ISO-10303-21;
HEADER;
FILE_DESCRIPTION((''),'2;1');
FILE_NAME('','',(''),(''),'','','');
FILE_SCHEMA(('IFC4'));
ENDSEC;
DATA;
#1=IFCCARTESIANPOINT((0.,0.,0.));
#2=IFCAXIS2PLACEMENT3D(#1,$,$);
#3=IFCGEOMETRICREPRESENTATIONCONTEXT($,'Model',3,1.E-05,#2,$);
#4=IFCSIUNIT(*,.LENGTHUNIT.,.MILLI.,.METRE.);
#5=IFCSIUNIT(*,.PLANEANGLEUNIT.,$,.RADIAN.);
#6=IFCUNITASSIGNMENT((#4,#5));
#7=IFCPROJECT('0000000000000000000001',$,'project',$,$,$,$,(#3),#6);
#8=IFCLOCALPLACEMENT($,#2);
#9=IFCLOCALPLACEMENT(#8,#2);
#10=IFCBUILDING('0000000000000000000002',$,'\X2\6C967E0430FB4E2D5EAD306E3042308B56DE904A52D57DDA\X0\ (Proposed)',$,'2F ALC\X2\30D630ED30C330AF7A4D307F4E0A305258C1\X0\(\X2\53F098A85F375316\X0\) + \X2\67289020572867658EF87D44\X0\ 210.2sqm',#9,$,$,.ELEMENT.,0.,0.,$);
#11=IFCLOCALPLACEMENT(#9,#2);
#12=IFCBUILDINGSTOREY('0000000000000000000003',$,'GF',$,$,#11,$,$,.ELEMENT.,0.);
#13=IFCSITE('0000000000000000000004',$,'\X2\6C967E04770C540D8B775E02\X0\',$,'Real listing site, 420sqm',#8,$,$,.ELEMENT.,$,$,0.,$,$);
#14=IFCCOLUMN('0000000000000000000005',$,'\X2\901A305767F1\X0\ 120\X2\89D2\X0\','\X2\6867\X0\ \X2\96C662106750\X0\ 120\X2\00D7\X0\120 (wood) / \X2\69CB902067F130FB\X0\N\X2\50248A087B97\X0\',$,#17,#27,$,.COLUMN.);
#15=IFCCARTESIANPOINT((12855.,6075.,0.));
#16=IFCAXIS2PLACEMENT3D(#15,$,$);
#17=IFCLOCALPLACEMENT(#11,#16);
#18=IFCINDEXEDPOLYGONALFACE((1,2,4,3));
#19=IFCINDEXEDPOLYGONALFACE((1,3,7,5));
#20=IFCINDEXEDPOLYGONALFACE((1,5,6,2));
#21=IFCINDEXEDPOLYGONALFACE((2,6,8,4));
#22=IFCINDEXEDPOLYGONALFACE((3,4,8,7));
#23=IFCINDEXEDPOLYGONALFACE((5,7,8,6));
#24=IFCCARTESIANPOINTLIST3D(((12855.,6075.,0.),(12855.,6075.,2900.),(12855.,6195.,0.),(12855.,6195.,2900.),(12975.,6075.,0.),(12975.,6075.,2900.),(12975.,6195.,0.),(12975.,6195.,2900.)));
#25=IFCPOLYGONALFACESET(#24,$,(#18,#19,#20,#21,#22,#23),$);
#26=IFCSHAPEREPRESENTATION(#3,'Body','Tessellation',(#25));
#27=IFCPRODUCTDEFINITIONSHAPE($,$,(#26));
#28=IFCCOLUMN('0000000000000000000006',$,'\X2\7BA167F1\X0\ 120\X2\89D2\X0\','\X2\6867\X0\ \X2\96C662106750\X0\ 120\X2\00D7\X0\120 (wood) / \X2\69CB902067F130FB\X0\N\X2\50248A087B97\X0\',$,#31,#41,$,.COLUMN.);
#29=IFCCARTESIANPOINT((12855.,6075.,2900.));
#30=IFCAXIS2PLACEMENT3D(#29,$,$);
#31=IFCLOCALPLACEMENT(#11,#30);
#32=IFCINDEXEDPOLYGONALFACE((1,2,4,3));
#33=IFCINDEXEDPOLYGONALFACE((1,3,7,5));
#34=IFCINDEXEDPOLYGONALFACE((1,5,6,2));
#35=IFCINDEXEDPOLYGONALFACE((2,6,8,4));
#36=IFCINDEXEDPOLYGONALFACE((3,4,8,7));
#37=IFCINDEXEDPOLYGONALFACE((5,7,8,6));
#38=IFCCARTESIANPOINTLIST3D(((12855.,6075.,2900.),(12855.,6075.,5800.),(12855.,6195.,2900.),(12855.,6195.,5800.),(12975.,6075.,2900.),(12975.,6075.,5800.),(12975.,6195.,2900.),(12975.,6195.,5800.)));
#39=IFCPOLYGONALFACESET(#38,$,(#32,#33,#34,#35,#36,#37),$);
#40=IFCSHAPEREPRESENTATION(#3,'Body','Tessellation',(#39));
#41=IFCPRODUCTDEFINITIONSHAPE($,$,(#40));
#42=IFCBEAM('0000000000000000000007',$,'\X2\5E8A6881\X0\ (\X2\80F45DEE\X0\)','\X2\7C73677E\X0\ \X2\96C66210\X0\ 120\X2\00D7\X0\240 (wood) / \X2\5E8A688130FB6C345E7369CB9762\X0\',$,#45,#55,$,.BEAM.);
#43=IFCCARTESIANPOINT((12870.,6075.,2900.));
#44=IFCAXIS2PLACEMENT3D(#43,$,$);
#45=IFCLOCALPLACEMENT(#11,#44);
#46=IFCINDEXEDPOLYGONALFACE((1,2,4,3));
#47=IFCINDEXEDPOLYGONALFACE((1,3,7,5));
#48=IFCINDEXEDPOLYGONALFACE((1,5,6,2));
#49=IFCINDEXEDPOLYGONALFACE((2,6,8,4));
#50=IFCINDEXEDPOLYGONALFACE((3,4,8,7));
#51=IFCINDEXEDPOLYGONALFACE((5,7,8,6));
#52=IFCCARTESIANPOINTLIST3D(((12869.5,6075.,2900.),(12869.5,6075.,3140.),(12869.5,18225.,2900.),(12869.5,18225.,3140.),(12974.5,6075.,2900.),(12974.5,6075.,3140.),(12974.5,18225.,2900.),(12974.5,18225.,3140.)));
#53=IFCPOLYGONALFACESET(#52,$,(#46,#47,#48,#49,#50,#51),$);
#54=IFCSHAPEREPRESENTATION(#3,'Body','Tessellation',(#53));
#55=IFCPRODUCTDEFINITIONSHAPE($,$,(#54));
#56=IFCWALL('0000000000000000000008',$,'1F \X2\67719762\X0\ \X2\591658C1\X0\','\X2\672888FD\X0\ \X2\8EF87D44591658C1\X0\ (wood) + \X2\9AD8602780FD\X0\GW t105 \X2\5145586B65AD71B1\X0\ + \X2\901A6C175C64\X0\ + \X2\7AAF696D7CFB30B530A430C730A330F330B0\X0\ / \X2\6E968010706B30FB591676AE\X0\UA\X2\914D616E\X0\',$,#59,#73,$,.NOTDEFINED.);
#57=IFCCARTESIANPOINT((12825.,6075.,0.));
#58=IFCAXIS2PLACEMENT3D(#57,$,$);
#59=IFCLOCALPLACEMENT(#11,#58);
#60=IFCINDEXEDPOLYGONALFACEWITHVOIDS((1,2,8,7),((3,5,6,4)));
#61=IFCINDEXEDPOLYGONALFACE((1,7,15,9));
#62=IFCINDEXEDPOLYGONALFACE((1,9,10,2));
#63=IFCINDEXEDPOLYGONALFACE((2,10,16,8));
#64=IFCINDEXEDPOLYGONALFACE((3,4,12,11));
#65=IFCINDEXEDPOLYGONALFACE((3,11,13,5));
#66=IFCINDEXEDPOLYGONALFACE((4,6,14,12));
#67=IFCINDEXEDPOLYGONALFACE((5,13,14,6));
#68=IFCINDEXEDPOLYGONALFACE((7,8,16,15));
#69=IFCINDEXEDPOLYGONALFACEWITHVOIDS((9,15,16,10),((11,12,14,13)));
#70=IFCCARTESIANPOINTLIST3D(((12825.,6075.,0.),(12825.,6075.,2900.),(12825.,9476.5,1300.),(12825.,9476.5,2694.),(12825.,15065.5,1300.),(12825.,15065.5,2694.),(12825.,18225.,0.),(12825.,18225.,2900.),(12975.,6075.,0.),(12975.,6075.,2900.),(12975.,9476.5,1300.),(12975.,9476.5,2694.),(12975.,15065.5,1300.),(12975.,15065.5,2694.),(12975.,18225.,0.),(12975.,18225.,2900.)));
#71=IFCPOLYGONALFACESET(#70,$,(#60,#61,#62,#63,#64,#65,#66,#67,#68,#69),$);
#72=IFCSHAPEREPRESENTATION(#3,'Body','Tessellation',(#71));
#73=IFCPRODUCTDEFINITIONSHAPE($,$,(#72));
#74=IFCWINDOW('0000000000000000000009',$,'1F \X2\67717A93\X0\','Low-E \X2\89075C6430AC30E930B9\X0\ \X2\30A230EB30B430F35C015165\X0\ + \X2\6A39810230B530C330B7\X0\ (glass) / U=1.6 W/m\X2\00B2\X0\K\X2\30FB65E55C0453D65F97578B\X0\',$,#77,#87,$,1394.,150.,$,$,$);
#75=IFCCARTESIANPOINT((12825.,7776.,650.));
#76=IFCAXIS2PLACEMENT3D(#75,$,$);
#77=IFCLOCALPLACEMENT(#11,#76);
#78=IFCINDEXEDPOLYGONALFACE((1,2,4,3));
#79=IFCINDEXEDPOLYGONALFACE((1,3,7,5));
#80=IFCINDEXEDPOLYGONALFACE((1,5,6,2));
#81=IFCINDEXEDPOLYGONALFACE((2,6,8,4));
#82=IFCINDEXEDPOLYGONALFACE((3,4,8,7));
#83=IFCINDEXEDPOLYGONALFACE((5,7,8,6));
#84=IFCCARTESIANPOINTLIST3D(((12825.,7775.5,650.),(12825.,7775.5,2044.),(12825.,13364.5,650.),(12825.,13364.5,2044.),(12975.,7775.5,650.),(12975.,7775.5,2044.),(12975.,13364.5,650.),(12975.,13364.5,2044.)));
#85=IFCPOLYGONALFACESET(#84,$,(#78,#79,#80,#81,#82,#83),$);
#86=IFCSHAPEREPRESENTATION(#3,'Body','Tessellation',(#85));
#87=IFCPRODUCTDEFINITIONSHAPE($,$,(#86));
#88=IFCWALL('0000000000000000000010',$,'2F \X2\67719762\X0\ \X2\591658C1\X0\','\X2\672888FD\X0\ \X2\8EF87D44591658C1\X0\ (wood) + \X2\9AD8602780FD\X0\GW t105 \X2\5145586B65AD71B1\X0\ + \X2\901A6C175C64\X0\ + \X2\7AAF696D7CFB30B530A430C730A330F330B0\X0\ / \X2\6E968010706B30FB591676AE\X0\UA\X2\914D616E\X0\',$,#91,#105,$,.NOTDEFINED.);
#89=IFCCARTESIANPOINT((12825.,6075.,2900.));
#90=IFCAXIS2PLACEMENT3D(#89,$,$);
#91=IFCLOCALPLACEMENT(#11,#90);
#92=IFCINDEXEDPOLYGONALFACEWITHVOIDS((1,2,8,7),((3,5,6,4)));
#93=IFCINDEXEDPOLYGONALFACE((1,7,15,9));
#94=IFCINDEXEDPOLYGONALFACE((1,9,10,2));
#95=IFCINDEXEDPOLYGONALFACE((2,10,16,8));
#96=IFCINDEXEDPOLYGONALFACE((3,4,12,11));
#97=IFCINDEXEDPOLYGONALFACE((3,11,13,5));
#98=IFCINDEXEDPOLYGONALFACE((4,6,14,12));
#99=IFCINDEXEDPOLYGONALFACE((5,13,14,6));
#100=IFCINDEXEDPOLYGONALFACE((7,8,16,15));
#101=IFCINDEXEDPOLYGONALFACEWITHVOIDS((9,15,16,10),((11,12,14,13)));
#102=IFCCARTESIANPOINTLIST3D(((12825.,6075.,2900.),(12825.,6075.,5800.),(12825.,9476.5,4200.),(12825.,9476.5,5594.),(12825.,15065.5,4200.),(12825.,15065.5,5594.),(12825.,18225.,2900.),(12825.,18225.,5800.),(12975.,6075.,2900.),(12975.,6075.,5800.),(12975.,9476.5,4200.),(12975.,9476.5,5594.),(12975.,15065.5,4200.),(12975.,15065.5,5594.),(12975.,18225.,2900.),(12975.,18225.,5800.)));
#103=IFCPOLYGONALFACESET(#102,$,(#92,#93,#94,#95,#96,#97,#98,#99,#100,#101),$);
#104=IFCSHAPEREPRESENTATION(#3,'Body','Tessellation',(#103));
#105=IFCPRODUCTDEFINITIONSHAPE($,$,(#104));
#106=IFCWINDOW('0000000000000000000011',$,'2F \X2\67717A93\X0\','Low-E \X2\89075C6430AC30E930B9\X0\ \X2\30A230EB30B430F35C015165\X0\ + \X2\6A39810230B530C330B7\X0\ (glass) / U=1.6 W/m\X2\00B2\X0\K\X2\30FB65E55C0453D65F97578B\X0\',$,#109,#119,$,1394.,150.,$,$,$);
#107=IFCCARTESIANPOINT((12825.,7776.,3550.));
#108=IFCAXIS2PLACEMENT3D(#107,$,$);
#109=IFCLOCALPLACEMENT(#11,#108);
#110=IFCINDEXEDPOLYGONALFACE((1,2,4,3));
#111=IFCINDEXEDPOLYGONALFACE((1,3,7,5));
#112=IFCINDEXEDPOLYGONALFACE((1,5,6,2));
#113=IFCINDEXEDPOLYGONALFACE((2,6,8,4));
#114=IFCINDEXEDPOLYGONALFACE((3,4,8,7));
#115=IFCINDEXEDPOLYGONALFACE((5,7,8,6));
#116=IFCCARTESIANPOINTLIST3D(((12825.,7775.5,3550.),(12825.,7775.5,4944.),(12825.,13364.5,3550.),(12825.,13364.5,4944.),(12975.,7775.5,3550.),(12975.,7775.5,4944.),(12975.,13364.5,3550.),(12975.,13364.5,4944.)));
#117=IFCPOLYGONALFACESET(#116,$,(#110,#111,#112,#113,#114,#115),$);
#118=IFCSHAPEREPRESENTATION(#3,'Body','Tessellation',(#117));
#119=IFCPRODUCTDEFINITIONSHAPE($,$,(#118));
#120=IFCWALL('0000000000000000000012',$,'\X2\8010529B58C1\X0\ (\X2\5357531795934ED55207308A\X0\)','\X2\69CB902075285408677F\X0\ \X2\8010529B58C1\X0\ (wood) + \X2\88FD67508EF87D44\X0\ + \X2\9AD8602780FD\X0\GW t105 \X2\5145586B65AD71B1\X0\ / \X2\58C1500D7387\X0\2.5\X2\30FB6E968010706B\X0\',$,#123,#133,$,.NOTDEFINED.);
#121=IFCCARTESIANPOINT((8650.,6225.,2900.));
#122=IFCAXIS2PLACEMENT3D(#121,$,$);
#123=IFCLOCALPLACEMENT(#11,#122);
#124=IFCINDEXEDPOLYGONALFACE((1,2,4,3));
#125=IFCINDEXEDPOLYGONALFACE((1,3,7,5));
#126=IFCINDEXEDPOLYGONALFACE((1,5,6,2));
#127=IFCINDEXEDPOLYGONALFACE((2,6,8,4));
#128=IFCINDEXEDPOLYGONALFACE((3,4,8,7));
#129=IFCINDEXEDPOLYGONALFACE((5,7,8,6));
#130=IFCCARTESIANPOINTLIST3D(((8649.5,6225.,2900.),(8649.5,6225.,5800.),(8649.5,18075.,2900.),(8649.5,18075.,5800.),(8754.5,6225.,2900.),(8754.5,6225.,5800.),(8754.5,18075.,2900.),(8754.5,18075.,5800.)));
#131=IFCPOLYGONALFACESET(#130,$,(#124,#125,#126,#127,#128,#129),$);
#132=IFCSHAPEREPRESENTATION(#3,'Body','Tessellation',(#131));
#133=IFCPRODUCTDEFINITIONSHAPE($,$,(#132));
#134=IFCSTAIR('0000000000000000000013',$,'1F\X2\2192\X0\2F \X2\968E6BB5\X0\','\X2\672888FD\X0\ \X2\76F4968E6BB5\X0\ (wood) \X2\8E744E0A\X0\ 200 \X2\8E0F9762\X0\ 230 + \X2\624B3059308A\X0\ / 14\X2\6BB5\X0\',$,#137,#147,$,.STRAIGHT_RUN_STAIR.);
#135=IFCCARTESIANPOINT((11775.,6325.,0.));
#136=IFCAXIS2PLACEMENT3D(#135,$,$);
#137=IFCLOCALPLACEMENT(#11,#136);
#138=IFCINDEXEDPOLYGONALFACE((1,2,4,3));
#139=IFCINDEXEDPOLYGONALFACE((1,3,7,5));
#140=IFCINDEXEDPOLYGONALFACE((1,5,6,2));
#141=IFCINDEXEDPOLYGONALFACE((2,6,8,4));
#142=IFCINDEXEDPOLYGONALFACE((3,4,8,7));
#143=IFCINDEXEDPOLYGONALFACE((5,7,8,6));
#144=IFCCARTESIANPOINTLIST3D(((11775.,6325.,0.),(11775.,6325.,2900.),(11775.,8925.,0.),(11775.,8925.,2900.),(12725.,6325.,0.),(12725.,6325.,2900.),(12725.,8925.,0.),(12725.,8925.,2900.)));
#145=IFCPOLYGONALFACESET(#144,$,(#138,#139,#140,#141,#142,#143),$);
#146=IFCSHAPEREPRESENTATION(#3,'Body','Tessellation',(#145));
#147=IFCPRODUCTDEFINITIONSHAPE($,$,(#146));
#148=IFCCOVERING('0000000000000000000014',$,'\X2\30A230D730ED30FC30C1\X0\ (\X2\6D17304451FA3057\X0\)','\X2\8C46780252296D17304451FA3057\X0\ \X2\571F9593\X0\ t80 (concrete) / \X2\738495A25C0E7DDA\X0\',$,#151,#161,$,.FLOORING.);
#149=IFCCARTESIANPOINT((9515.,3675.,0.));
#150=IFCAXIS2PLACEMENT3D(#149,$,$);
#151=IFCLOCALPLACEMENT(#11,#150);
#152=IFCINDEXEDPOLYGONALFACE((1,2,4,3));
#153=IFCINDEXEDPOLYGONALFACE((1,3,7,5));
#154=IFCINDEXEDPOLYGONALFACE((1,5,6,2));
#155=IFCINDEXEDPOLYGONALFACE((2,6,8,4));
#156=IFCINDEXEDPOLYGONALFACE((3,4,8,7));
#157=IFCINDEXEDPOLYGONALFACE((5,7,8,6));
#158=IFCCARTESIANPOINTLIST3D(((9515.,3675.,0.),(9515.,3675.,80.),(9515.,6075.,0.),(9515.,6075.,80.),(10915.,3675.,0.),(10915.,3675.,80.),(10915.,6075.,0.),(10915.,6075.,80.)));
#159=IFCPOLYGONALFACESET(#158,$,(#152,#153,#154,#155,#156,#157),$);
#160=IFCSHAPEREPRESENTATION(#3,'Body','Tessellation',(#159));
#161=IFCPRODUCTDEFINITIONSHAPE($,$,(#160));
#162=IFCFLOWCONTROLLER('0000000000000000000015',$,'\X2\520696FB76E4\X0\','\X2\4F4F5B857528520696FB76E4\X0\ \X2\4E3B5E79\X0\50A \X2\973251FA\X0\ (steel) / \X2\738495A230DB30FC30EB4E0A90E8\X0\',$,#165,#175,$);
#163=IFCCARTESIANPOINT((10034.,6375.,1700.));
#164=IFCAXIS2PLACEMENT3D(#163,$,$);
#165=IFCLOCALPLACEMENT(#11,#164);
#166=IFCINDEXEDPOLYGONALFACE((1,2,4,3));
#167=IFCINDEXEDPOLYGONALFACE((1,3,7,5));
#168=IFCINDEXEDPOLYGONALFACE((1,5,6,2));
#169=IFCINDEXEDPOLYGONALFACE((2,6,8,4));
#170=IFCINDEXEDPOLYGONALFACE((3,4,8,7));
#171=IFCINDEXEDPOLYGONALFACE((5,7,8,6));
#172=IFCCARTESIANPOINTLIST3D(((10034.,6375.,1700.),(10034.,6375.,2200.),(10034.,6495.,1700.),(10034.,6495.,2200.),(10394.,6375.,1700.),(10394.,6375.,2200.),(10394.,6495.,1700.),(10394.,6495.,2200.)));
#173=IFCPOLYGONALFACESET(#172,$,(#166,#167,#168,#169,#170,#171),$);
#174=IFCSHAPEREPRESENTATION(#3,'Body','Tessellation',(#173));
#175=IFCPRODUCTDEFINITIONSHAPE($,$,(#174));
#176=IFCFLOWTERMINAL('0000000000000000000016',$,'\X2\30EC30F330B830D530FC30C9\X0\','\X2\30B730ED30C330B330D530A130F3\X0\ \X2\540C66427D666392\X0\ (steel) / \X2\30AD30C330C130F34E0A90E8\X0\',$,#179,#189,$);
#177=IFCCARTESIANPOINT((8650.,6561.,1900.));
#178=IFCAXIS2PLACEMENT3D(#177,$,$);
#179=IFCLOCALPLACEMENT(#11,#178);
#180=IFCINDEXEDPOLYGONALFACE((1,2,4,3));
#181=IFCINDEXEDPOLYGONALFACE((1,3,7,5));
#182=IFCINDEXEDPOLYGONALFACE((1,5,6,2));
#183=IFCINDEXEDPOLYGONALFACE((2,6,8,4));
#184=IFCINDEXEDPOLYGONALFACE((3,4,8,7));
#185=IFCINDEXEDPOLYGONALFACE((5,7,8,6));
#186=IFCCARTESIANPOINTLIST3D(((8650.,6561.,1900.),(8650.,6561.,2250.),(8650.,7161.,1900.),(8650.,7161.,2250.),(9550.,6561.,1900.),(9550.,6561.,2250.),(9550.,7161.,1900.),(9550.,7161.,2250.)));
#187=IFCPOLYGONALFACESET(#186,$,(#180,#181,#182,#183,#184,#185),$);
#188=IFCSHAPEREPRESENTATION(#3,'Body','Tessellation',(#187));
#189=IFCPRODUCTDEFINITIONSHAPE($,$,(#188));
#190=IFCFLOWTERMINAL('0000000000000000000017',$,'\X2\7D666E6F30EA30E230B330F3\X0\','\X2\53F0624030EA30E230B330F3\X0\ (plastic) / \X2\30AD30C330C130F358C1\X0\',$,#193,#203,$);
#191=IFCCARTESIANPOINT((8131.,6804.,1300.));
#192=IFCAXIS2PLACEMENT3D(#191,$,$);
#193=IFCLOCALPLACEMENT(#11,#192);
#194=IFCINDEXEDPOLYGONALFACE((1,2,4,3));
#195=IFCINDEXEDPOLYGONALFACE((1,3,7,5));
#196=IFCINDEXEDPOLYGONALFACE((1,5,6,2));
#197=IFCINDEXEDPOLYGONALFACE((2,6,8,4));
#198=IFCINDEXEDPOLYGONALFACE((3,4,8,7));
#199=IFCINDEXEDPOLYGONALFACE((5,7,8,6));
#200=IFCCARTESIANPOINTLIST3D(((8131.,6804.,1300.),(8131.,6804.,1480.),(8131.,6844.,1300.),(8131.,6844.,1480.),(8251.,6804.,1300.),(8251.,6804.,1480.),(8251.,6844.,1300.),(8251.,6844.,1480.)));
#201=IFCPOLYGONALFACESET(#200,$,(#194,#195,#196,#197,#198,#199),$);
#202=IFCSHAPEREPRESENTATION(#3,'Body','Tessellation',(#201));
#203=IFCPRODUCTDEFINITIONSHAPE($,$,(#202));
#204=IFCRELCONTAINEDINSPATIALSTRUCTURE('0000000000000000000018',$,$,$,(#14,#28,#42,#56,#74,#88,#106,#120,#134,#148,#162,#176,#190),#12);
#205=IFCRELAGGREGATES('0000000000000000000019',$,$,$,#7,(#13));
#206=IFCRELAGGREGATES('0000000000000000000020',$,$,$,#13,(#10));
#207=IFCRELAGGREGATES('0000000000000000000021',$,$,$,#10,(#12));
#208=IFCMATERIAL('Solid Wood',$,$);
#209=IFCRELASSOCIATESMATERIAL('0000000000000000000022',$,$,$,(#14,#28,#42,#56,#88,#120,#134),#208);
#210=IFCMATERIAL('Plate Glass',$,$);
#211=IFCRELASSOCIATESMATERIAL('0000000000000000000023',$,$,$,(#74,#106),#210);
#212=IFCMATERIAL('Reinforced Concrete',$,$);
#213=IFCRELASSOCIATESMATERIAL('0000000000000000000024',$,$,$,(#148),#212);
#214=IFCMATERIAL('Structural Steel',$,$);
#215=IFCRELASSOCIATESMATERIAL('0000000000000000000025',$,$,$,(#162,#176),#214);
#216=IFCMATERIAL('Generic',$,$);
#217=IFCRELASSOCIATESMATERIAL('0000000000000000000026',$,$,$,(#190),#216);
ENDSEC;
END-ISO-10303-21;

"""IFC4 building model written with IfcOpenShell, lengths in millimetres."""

from ifc_helpers import new_model, si_unit, frame, frame_2d, origin, place, context, project, spatial, rectangle, extrude, material, element, fill, save


model = new_model("IFC4")

# Units and contexts
model_context = context("Model", 3, precision=1e-05, world=origin())
ifc_project = project(units=[si_unit("LENGTHUNIT", "METRE", prefix="MILLI"), si_unit("PLANEANGLEUNIT", "RADIAN")], contexts=[model_context])

# Site, building, storey
site_placement = place(None, origin())
site = spatial("IfcSite", under=ifc_project, at=site_placement, Name="沖縄県名護市", ObjectType="Real listing site, 420sqm", CompositionType="ELEMENT", RefElevation=0.0)
building_placement = place(site_placement, origin())
building = spatial("IfcBuilding", under=site, at=building_placement, Name="沖縄・中庭のある回遊動線 (Proposed)", ObjectType="2F ALCブロック積み上げ壁(台風強化) + 木造在来軸組 210.2sqm", CompositionType="ELEMENT", ElevationOfRefHeight=0.0, ElevationOfTerrain=0.0)
storey_placement = place(building_placement, origin())
storey = spatial("IfcBuildingStorey", under=building, at=storey_placement, Name="GF", CompositionType="ELEMENT", Elevation=0.0)

# Columns
ifc_material_1 = material(Name="Solid Wood")
column_1_placement = place(storey_placement, frame((12855.0, 6075.0, 0.0)))
element("IfcColumn", 1, at=column_1_placement, inside=storey, material=ifc_material_1, Name="通し柱 120角", Description="桧 集成材 120×120 (wood) / 構造柱・N値計算", PredefinedType="COLUMN", context=model_context, shape_type="SweptSolid", body=[
    extrude(rectangle(XDim=120.0, YDim=120.0, at=frame_2d((60.0, 60.0))), frame((12855.0, 6075.0, 0.0)), (0.0, 0.0, 1.0), 2900.0),
])
column_2_placement = place(storey_placement, frame((12855.0, 6075.0, 2900.0)))
element("IfcColumn", 2, at=column_2_placement, inside=storey, material=ifc_material_1, Name="管柱 120角", Description="桧 集成材 120×120 (wood) / 構造柱・N値計算", PredefinedType="COLUMN", context=model_context, shape_type="SweptSolid", body=[
    extrude(rectangle(XDim=120.0, YDim=120.0, at=frame_2d((60.0, 60.0))), frame((12855.0, 6075.0, 2900.0)), (0.0, 0.0, 1.0), 2900.0),
])

# Beam
beam_1_placement = place(storey_placement, frame((12870.0, 6075.0, 2900.0)))
element("IfcBeam", 3, at=beam_1_placement, inside=storey, material=ifc_material_1, Name="床梁 (胴差)", Description="米松 集成 120×240 (wood) / 床梁・水平構面", PredefinedType="BEAM", context=model_context, shape_type="SweptSolid", body=[
    extrude(rectangle(XDim=105.0, YDim=12150.0, at=frame_2d((52.0, 6075.0))), frame((12870.0, 6075.0, 2900.0)), (0.0, 0.0, 1.0), 240.0),
])

# Wall, opening, window
wall_1_placement = place(storey_placement, frame((12825.0, 6075.0, 0.0)))
wall_1 = element("IfcWall", 4, at=wall_1_placement, inside=storey, material=ifc_material_1, Name="1F 東面 外壁", Description="木製 軸組外壁 (wood) + 高性能GW t105 充填断熱 + 通気層 + 窯業系サイディング / 準耐火・外皮UA配慮", PredefinedType="NOTDEFINED", context=model_context, shape_type="SweptSolid", body=[
    extrude(rectangle(XDim=150.0, YDim=12150.0, at=frame_2d((75.0, 6075.0))), frame((12825.0, 6075.0, 0.0)), (0.0, 0.0, 1.0), 2900.0),
])
opening_1_placement = place(storey_placement, frame((12825.0, 7776.0, 650.0)))
opening_1 = element("IfcOpeningElement", 5, at=opening_1_placement, cuts=wall_1, PredefinedType="NOTDEFINED", context=model_context, shape_type="SweptSolid", body=[
    extrude(rectangle(XDim=150.0, YDim=5589.0, at=frame_2d((75.0, 2794.0))), frame((12825.0, 7776.0, 650.0)), (0.0, 0.0, 1.0), 1394.0),
])
ifc_material_2 = material(Name="Plate Glass")
window_1_placement = place(storey_placement, frame((12825.0, 7776.0, 650.0)))
window_1 = element("IfcWindow", 6, at=window_1_placement, inside=storey, material=ifc_material_2, Name="1F 東窓", Description="Low-E 複層ガラス アルゴン封入 + 樹脂サッシ (glass) / U=1.6 W/m²K・日射取得型", OverallHeight=1394.0, OverallWidth=150.0, context=model_context, shape_type="SweptSolid", body=[
    extrude(rectangle(XDim=150.0, YDim=5589.0, at=frame_2d((75.0, 2794.0))), frame((12825.0, 7776.0, 650.0)), (0.0, 0.0, 1.0), 1394.0),
])
fill(opening_1, window_1)

# Wall, opening, window
wall_2_placement = place(storey_placement, frame((12825.0, 6075.0, 2900.0)))
wall_2 = element("IfcWall", 7, at=wall_2_placement, inside=storey, material=ifc_material_1, Name="2F 東面 外壁", Description="木製 軸組外壁 (wood) + 高性能GW t105 充填断熱 + 通気層 + 窯業系サイディング / 準耐火・外皮UA配慮", PredefinedType="NOTDEFINED", context=model_context, shape_type="SweptSolid", body=[
    extrude(rectangle(XDim=150.0, YDim=12150.0, at=frame_2d((75.0, 6075.0))), frame((12825.0, 6075.0, 2900.0)), (0.0, 0.0, 1.0), 2900.0),
])
opening_2_placement = place(storey_placement, frame((12825.0, 7776.0, 3550.0)))
opening_2 = element("IfcOpeningElement", 8, at=opening_2_placement, cuts=wall_2, PredefinedType="NOTDEFINED", context=model_context, shape_type="SweptSolid", body=[
    extrude(rectangle(XDim=150.0, YDim=5589.0, at=frame_2d((75.0, 2794.0))), frame((12825.0, 7776.0, 3550.0)), (0.0, 0.0, 1.0), 1394.0),
])
window_2_placement = place(storey_placement, frame((12825.0, 7776.0, 3550.0)))
window_2 = element("IfcWindow", 9, at=window_2_placement, inside=storey, material=ifc_material_2, Name="2F 東窓", Description="Low-E 複層ガラス アルゴン封入 + 樹脂サッシ (glass) / U=1.6 W/m²K・日射取得型", OverallHeight=1394.0, OverallWidth=150.0, context=model_context, shape_type="SweptSolid", body=[
    extrude(rectangle(XDim=150.0, YDim=5589.0, at=frame_2d((75.0, 2794.0))), frame((12825.0, 7776.0, 3550.0)), (0.0, 0.0, 1.0), 1394.0),
])
fill(opening_2, window_2)

# Wall
wall_3_placement = place(storey_placement, frame((8650.0, 6225.0, 2900.0)))
element("IfcWall", 10, at=wall_3_placement, inside=storey, material=ifc_material_1, Name="耐力壁 (南北間仕切り)", Description="構造用合板 耐力壁 (wood) + 製材軸組 + 高性能GW t105 充填断熱 / 壁倍率2.5・準耐火", PredefinedType="NOTDEFINED", context=model_context, shape_type="SweptSolid", body=[
    extrude(rectangle(XDim=105.0, YDim=11850.0, at=frame_2d((52.0, 5925.0))), frame((8650.0, 6225.0, 2900.0)), (0.0, 0.0, 1.0), 2900.0),
])

# Stair
stair_placement = place(storey_placement, frame((11775.0, 6325.0, 0.0)))
element("IfcStair", 11, at=stair_placement, inside=storey, material=ifc_material_1, Name="1F→2F 階段", Description="木製 直階段 (wood) 蹴上 200 踏面 230 + 手すり / 14段", PredefinedType="STRAIGHT_RUN_STAIR", context=model_context, shape_type="SweptSolid", body=[
    extrude(rectangle(XDim=950.0, YDim=2600.0, at=frame_2d((475.0, 1300.0))), frame((11775.0, 6325.0, 0.0)), (0.0, 0.0, 1.0), 2900.0),
])

# Covering
ifc_material_3 = material(Name="Reinforced Concrete")
covering_placement = place(storey_placement, frame((9515.0, 3675.0, 0.0)))
element("IfcCovering", 12, at=covering_placement, inside=storey, material=ifc_material_3, Name="アプローチ (洗い出し)", Description="豆砂利洗い出し 土間 t80 (concrete) / 玄関導線", PredefinedType="FLOORING", context=model_context, shape_type="SweptSolid", body=[
    extrude(rectangle(XDim=1400.0, YDim=2400.0, at=frame_2d((700.0, 1200.0))), frame((9515.0, 3675.0, 0.0)), (0.0, 0.0, 1.0), 80.0),
])

# Flow controller
ifc_material_4 = material(Name="Structural Steel")
flow_controller_placement = place(storey_placement, frame((10034.0, 6375.0, 1700.0)))
element("IfcFlowController", 13, at=flow_controller_placement, inside=storey, material=ifc_material_4, Name="分電盤", Description="住宅用分電盤 主幹50A 露出 (steel) / 玄関ホール上部", context=model_context, shape_type="SweptSolid", body=[
    extrude(rectangle(XDim=360.0, YDim=120.0, at=frame_2d((180.0, 60.0))), frame((10034.0, 6375.0, 1700.0)), (0.0, 0.0, 1.0), 500.0),
])

# Flow terminals
flow_terminal_1_placement = place(storey_placement, frame((8650.0, 6561.0, 1900.0)))
element("IfcFlowTerminal", 14, at=flow_terminal_1_placement, inside=storey, material=ifc_material_4, Name="レンジフード", Description="シロッコファン 同時給排 (steel) / キッチン上部", context=model_context, shape_type="SweptSolid", body=[
    extrude(rectangle(XDim=900.0, YDim=600.0, at=frame_2d((450.0, 300.0))), frame((8650.0, 6561.0, 1900.0)), (0.0, 0.0, 1.0), 350.0),
])
ifc_material_5 = material(Name="Generic")
flow_terminal_2_placement = place(storey_placement, frame((8131.0, 6804.0, 1300.0)))
element("IfcFlowTerminal", 15, at=flow_terminal_2_placement, inside=storey, material=ifc_material_5, Name="給湯リモコン", Description="台所リモコン (plastic) / キッチン壁", context=model_context, shape_type="SweptSolid", body=[
    extrude(rectangle(XDim=120.0, YDim=40.0, at=frame_2d((60.0, 20.0))), frame((8131.0, 6804.0, 1300.0)), (0.0, 0.0, 1.0), 180.0),
])

save(model, "model.ifc")
